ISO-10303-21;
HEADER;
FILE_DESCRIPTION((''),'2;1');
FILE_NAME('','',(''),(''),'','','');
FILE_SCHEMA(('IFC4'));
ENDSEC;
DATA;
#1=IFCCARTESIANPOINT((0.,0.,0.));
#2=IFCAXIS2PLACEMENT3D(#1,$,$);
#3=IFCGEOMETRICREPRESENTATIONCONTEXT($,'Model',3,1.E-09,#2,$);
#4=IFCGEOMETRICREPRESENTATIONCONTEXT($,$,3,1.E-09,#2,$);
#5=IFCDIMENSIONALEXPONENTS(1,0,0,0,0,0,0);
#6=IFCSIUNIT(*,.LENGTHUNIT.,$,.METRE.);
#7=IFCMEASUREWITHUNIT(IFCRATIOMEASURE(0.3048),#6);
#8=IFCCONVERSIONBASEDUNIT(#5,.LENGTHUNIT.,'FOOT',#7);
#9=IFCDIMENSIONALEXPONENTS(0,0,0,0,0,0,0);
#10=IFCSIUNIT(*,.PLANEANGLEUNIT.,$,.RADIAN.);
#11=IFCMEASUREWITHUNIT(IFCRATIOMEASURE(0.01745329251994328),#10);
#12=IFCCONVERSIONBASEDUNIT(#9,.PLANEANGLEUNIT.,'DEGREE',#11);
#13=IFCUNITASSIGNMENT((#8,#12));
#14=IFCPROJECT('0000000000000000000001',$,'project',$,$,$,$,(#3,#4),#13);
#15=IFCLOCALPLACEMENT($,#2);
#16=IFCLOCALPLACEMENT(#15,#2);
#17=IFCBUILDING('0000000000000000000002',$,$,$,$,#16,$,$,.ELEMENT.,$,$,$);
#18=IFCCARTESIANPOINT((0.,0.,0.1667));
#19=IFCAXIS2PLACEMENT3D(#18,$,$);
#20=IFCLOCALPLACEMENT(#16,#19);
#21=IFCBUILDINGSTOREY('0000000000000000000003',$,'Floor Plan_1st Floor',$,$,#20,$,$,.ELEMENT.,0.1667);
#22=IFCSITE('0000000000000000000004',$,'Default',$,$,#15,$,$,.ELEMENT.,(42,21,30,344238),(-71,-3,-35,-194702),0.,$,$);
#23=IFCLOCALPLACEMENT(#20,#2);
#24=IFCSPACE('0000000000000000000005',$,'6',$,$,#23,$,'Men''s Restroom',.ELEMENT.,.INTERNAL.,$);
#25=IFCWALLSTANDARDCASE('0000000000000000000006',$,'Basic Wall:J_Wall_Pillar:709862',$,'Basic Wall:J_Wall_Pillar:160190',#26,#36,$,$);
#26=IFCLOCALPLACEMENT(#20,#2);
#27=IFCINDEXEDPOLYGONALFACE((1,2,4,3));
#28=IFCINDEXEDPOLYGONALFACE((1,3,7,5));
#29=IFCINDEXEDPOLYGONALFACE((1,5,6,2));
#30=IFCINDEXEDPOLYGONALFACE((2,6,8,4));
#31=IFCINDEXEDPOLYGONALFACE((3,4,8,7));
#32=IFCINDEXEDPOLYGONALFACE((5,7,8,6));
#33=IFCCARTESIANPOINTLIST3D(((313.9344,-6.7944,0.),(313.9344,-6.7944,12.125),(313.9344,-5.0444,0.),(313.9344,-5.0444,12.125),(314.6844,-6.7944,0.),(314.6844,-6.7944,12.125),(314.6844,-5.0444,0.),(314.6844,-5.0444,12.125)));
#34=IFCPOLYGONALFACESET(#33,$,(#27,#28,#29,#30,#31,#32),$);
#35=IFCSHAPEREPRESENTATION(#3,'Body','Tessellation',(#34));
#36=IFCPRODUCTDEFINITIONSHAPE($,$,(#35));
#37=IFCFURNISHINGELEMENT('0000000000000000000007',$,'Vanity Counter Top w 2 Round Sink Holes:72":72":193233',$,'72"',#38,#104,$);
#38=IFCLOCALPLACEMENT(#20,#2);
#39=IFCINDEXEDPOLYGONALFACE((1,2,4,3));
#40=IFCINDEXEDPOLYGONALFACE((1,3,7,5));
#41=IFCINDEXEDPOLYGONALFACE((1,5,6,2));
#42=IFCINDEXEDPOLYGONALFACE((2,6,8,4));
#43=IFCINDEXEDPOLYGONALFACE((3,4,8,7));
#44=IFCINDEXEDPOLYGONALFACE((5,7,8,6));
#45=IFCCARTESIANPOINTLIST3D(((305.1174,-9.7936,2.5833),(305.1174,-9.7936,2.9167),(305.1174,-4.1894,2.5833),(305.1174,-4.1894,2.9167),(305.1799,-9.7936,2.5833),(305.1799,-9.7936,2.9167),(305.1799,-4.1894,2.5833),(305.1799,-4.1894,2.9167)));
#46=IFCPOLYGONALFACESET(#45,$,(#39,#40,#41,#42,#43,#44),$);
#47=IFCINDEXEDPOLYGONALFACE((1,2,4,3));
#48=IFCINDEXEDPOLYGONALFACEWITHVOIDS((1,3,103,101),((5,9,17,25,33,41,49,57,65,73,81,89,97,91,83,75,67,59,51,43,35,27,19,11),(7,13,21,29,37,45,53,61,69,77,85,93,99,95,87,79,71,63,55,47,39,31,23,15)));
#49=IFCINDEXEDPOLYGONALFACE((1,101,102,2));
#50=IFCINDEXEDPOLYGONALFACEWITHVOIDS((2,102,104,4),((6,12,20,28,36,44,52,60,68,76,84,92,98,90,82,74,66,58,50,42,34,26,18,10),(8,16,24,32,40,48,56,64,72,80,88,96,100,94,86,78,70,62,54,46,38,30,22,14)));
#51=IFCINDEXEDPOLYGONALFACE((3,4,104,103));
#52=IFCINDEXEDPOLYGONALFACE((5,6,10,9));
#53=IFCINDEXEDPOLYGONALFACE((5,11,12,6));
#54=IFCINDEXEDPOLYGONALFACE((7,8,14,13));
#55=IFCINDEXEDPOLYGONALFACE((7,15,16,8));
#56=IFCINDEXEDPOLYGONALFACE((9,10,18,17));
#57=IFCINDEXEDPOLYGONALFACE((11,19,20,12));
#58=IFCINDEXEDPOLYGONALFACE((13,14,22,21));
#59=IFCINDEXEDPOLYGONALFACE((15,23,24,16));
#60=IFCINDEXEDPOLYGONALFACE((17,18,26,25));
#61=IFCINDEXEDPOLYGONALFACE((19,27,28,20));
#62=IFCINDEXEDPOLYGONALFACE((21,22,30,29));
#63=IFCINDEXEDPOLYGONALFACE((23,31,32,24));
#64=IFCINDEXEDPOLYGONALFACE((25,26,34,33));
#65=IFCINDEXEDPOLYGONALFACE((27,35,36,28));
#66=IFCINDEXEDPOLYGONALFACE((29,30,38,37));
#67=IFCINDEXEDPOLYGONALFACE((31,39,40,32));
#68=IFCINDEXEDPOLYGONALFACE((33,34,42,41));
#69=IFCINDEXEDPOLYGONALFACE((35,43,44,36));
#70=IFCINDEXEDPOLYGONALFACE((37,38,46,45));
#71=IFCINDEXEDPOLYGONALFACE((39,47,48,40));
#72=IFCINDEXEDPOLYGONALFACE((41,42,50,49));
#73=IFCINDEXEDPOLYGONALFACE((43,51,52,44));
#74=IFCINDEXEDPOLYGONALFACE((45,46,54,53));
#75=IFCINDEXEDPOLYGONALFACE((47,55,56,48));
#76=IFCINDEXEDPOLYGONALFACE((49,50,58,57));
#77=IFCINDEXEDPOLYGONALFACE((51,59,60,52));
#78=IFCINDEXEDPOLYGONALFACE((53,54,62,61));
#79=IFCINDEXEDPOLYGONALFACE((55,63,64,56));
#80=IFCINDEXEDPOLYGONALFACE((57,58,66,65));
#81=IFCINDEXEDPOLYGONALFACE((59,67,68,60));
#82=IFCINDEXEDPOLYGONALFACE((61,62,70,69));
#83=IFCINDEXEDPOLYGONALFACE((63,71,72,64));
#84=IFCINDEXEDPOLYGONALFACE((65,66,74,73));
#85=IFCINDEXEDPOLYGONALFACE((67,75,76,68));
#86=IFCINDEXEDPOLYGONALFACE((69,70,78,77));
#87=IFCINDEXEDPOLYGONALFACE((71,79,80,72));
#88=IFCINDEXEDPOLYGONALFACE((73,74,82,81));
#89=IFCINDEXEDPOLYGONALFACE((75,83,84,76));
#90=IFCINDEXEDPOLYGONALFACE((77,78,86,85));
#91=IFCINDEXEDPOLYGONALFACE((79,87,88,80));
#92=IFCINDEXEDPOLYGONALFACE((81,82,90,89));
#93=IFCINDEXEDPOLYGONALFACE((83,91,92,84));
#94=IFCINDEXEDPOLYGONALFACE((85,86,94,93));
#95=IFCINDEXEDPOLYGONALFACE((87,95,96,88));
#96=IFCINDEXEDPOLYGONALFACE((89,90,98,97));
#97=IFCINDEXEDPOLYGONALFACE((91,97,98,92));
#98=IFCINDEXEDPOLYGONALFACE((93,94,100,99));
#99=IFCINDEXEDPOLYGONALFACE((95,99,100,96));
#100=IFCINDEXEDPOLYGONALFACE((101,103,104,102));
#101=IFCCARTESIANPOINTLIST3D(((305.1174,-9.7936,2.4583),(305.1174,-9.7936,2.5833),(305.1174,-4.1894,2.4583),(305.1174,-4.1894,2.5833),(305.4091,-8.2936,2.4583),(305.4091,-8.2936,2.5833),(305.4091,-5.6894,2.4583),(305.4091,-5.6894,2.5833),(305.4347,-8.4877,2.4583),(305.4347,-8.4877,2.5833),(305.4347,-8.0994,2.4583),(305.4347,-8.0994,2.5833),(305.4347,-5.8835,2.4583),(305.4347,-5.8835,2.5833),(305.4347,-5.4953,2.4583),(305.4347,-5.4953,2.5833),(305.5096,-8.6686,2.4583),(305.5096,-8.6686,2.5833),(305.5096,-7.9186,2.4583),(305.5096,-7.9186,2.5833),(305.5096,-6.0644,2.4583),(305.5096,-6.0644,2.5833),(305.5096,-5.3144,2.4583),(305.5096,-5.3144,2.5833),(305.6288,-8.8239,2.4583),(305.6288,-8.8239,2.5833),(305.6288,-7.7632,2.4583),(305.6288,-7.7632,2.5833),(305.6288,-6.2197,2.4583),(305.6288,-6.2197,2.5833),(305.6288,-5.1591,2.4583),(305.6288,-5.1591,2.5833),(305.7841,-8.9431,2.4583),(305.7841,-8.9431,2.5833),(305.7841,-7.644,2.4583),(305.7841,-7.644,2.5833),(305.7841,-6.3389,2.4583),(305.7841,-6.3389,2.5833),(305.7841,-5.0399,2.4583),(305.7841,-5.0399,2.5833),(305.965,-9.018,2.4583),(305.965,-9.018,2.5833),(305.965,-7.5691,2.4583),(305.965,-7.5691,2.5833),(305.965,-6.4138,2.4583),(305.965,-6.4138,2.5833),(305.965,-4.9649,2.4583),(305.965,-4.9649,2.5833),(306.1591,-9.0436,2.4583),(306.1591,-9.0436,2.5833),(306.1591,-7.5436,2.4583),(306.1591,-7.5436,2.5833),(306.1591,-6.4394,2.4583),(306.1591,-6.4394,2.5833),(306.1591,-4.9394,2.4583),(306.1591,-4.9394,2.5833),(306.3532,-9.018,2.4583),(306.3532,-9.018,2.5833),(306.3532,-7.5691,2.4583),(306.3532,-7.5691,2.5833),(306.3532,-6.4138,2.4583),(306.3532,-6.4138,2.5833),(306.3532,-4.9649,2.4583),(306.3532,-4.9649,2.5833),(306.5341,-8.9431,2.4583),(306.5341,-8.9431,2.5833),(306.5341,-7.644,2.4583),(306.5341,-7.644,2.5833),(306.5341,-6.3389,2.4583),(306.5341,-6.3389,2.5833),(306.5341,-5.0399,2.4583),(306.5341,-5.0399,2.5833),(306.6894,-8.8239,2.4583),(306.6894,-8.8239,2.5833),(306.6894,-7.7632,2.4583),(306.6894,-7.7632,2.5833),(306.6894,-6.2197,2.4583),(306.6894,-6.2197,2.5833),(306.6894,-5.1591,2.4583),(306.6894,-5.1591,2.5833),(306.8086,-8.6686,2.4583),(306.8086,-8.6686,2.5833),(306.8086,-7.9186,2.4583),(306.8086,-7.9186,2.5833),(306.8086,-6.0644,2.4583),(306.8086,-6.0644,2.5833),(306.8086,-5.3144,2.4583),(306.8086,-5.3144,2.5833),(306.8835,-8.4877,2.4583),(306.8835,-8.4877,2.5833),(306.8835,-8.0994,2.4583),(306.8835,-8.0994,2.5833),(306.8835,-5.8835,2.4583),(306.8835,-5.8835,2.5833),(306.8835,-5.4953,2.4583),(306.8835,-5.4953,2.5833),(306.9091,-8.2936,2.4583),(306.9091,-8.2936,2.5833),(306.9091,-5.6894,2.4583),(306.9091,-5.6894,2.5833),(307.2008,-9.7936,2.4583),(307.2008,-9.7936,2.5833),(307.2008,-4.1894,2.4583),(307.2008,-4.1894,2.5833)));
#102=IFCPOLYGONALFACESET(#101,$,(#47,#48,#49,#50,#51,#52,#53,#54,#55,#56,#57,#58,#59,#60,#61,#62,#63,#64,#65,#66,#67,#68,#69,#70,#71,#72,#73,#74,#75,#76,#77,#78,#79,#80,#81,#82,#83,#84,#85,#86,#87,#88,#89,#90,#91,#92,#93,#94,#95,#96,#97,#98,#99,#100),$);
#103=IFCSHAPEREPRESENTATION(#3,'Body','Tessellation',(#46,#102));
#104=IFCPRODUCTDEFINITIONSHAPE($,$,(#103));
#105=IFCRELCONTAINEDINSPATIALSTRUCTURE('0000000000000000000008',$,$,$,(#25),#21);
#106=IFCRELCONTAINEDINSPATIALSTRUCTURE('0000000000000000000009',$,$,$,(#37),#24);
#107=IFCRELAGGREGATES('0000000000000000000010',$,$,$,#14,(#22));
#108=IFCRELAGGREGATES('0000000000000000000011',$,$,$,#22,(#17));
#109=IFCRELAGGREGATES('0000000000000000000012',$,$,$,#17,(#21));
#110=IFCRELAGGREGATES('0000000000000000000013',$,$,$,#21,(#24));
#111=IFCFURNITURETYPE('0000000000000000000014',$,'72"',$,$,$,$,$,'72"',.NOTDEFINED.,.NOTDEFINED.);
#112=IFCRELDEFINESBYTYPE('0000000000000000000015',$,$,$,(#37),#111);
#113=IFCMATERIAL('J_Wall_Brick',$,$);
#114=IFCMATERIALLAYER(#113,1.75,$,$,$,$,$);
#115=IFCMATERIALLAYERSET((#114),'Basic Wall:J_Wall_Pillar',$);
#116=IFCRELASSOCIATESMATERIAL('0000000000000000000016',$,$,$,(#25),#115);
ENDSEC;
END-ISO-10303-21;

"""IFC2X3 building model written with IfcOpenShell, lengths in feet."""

from ifc_helpers import new_model, entity, si_unit, converted_unit, frame, frame_2d, origin, origin_2d_with_axis, place, context, project, spatial, polyline, circle_curve, parameter, trimmed, segment, composite_curve, rectangle, outline, extrude, clip, halfspace, source, transform, mapped, material, layer, layer_set, layer_usage, type_object, type_shapes, element, save


model = new_model("IFC2X3")

# Units and contexts
model_context = context("Model", 3, precision=1e-09, world=origin())
context_of_model = context(None, 3, precision=1e-09, world=origin())
ifc_project = project(units=[converted_unit("LENGTHUNIT", "FOOT", entity("IfcRatioMeasure", 0.3048), si_unit("LENGTHUNIT", "METRE"), dimensions=[1, 0, 0, 0, 0, 0, 0]), converted_unit("PLANEANGLEUNIT", "DEGREE", entity("IfcRatioMeasure", 0.01745329251994328), si_unit("PLANEANGLEUNIT", "RADIAN"), dimensions=[0, 0, 0, 0, 0, 0, 0])], contexts=[model_context, context_of_model])

# Site, building, storey
site_placement = place(None, origin())
site = spatial("IfcSite", under=ifc_project, at=site_placement, Name="Default", CompositionType="ELEMENT", RefLatitude=(42, 21, 30, 344238), RefLongitude=(-71, -3, -35, -194702), RefElevation=0.0)
building_placement = place(site_placement, origin())
building = spatial("IfcBuilding", under=site, at=building_placement, CompositionType="ELEMENT")
storey_placement = place(building_placement, frame((0.0, 0.0, 0.1667)))
storey = spatial("IfcBuildingStorey", under=building, at=storey_placement, Name="Floor Plan_1st Floor", CompositionType="ELEMENT", Elevation=0.1667)

# Wall
ifc_material_1 = material(Name="J_Wall_Brick")
ifc_layer_1 = layer(ifc_material_1, 1.75)
ifc_layer_set_1 = layer_set([ifc_layer_1], Name="Basic Wall:J_Wall_Pillar")
ifc_layer_usage_1 = layer_usage(ifc_layer_set_1, "AXIS2", "NEGATIVE", 0.875)
wall_1_placement = place(storey_placement, frame((314.6844, -5.9194, 0.0), z_axis=(0.0, 0.0, 1.0), x_axis=(-1.0, 0.0, 0.0)))
element("IfcWallStandardCase", 1, at=wall_1_placement, inside=storey, material=ifc_layer_usage_1, Name="Basic Wall:J_Wall_Pillar:709862", ObjectType="Basic Wall:J_Wall_Pillar:160190", context=model_context, shape_type="Clipping", body=[
    clip(extrude(rectangle(XDim=0.75, YDim=1.75, at=frame_2d((0.375, 0.0), x_axis=(-1.0, 0.0))), origin(), (0.0, 0.0, 1.0), 12.125), halfspace(origin(), True)),
])

# Shared definitions
space_1_placement = place(storey_placement, origin())
space_1 = spatial("IfcSpace", under=storey, at=space_1_placement, Name="6", LongName="Men's Restroom", CompositionType="ELEMENT", InteriorOrExteriorSpace="INTERNAL")

# Furnishing element
furniture_type_1 = type_object("IfcFurnitureType", Name="72\"", ElementType="72\"", AssemblyPlace="NOTDEFINED")
shared_shape_1 = source(origin(), model_context, "Body", "SweptSolid", [
    extrude(rectangle(XDim=0.0625, YDim=5.6042, at=origin_2d_with_axis()), frame((-1.5531, -0.0313, 2.5833), z_axis=(0.0, 0.0, 1.0), x_axis=(0.0, -1.0, 0.0)), (0.0, 0.0, 1.0), 0.3333),
    extrude(outline(polyline([(-2.8021, -1.0417), (2.8021, -1.0417), (2.8021, 1.0417), (-2.8021, 1.0417), (-2.8021, -1.0417)]), holes=[composite_curve([segment(trimmed(circle_curve(frame_2d((1.3021, 0.0), x_axis=(-1.0, 0.0)), 0.75), [parameter(180.0)], [parameter(0.0)], True, "PARAMETER"), False, "CONTINUOUS"), segment(trimmed(circle_curve(frame_2d((1.3021, 0.0), x_axis=(-1.0, 0.0)), 0.75), [parameter(0.0)], [parameter(180.0)], True, "PARAMETER"), False, "CONTINUOUS")], self_intersect=False), composite_curve([segment(trimmed(circle_curve(frame_2d((-1.3021, 0.0), x_axis=(-1.0, 0.0)), 0.75), [parameter(180.0)], [parameter(360.0)], True, "PARAMETER"), False, "CONTINUOUS"), segment(trimmed(circle_curve(frame_2d((-1.3021, 0.0), x_axis=(-1.0, 0.0)), 0.75), [parameter(0.0)], [parameter(180.0)], True, "PARAMETER"), False, "CONTINUOUS")], self_intersect=False)]), frame((-1.5531, -1.0417, 2.4583), z_axis=(0.0, 0.0, 1.0), x_axis=(-1.0, 0.0, 0.0)), (0.0, 0.0, 1.0), 0.125),
])
type_shapes(furniture_type_1, [shared_shape_1])
furnishing_1_placement = place(space_1_placement, frame((305.1174, -5.4384, 0.0), z_axis=(0.0, 0.0, 1.0), x_axis=(0.0, 1.0, 0.0)))
element("IfcFurnishingElement", 2, at=furnishing_1_placement, inside=space_1, type_object=furniture_type_1, Name="Vanity Counter Top w 2 Round Sink Holes:72\":72\":193233", ObjectType="72\"", context=model_context, shape_type="MappedRepresentation", body=[
    mapped(shared_shape_1, transform((0.0, 0.0, 0.0), scale=1.0)),
])

save(model, "model.ifc")
